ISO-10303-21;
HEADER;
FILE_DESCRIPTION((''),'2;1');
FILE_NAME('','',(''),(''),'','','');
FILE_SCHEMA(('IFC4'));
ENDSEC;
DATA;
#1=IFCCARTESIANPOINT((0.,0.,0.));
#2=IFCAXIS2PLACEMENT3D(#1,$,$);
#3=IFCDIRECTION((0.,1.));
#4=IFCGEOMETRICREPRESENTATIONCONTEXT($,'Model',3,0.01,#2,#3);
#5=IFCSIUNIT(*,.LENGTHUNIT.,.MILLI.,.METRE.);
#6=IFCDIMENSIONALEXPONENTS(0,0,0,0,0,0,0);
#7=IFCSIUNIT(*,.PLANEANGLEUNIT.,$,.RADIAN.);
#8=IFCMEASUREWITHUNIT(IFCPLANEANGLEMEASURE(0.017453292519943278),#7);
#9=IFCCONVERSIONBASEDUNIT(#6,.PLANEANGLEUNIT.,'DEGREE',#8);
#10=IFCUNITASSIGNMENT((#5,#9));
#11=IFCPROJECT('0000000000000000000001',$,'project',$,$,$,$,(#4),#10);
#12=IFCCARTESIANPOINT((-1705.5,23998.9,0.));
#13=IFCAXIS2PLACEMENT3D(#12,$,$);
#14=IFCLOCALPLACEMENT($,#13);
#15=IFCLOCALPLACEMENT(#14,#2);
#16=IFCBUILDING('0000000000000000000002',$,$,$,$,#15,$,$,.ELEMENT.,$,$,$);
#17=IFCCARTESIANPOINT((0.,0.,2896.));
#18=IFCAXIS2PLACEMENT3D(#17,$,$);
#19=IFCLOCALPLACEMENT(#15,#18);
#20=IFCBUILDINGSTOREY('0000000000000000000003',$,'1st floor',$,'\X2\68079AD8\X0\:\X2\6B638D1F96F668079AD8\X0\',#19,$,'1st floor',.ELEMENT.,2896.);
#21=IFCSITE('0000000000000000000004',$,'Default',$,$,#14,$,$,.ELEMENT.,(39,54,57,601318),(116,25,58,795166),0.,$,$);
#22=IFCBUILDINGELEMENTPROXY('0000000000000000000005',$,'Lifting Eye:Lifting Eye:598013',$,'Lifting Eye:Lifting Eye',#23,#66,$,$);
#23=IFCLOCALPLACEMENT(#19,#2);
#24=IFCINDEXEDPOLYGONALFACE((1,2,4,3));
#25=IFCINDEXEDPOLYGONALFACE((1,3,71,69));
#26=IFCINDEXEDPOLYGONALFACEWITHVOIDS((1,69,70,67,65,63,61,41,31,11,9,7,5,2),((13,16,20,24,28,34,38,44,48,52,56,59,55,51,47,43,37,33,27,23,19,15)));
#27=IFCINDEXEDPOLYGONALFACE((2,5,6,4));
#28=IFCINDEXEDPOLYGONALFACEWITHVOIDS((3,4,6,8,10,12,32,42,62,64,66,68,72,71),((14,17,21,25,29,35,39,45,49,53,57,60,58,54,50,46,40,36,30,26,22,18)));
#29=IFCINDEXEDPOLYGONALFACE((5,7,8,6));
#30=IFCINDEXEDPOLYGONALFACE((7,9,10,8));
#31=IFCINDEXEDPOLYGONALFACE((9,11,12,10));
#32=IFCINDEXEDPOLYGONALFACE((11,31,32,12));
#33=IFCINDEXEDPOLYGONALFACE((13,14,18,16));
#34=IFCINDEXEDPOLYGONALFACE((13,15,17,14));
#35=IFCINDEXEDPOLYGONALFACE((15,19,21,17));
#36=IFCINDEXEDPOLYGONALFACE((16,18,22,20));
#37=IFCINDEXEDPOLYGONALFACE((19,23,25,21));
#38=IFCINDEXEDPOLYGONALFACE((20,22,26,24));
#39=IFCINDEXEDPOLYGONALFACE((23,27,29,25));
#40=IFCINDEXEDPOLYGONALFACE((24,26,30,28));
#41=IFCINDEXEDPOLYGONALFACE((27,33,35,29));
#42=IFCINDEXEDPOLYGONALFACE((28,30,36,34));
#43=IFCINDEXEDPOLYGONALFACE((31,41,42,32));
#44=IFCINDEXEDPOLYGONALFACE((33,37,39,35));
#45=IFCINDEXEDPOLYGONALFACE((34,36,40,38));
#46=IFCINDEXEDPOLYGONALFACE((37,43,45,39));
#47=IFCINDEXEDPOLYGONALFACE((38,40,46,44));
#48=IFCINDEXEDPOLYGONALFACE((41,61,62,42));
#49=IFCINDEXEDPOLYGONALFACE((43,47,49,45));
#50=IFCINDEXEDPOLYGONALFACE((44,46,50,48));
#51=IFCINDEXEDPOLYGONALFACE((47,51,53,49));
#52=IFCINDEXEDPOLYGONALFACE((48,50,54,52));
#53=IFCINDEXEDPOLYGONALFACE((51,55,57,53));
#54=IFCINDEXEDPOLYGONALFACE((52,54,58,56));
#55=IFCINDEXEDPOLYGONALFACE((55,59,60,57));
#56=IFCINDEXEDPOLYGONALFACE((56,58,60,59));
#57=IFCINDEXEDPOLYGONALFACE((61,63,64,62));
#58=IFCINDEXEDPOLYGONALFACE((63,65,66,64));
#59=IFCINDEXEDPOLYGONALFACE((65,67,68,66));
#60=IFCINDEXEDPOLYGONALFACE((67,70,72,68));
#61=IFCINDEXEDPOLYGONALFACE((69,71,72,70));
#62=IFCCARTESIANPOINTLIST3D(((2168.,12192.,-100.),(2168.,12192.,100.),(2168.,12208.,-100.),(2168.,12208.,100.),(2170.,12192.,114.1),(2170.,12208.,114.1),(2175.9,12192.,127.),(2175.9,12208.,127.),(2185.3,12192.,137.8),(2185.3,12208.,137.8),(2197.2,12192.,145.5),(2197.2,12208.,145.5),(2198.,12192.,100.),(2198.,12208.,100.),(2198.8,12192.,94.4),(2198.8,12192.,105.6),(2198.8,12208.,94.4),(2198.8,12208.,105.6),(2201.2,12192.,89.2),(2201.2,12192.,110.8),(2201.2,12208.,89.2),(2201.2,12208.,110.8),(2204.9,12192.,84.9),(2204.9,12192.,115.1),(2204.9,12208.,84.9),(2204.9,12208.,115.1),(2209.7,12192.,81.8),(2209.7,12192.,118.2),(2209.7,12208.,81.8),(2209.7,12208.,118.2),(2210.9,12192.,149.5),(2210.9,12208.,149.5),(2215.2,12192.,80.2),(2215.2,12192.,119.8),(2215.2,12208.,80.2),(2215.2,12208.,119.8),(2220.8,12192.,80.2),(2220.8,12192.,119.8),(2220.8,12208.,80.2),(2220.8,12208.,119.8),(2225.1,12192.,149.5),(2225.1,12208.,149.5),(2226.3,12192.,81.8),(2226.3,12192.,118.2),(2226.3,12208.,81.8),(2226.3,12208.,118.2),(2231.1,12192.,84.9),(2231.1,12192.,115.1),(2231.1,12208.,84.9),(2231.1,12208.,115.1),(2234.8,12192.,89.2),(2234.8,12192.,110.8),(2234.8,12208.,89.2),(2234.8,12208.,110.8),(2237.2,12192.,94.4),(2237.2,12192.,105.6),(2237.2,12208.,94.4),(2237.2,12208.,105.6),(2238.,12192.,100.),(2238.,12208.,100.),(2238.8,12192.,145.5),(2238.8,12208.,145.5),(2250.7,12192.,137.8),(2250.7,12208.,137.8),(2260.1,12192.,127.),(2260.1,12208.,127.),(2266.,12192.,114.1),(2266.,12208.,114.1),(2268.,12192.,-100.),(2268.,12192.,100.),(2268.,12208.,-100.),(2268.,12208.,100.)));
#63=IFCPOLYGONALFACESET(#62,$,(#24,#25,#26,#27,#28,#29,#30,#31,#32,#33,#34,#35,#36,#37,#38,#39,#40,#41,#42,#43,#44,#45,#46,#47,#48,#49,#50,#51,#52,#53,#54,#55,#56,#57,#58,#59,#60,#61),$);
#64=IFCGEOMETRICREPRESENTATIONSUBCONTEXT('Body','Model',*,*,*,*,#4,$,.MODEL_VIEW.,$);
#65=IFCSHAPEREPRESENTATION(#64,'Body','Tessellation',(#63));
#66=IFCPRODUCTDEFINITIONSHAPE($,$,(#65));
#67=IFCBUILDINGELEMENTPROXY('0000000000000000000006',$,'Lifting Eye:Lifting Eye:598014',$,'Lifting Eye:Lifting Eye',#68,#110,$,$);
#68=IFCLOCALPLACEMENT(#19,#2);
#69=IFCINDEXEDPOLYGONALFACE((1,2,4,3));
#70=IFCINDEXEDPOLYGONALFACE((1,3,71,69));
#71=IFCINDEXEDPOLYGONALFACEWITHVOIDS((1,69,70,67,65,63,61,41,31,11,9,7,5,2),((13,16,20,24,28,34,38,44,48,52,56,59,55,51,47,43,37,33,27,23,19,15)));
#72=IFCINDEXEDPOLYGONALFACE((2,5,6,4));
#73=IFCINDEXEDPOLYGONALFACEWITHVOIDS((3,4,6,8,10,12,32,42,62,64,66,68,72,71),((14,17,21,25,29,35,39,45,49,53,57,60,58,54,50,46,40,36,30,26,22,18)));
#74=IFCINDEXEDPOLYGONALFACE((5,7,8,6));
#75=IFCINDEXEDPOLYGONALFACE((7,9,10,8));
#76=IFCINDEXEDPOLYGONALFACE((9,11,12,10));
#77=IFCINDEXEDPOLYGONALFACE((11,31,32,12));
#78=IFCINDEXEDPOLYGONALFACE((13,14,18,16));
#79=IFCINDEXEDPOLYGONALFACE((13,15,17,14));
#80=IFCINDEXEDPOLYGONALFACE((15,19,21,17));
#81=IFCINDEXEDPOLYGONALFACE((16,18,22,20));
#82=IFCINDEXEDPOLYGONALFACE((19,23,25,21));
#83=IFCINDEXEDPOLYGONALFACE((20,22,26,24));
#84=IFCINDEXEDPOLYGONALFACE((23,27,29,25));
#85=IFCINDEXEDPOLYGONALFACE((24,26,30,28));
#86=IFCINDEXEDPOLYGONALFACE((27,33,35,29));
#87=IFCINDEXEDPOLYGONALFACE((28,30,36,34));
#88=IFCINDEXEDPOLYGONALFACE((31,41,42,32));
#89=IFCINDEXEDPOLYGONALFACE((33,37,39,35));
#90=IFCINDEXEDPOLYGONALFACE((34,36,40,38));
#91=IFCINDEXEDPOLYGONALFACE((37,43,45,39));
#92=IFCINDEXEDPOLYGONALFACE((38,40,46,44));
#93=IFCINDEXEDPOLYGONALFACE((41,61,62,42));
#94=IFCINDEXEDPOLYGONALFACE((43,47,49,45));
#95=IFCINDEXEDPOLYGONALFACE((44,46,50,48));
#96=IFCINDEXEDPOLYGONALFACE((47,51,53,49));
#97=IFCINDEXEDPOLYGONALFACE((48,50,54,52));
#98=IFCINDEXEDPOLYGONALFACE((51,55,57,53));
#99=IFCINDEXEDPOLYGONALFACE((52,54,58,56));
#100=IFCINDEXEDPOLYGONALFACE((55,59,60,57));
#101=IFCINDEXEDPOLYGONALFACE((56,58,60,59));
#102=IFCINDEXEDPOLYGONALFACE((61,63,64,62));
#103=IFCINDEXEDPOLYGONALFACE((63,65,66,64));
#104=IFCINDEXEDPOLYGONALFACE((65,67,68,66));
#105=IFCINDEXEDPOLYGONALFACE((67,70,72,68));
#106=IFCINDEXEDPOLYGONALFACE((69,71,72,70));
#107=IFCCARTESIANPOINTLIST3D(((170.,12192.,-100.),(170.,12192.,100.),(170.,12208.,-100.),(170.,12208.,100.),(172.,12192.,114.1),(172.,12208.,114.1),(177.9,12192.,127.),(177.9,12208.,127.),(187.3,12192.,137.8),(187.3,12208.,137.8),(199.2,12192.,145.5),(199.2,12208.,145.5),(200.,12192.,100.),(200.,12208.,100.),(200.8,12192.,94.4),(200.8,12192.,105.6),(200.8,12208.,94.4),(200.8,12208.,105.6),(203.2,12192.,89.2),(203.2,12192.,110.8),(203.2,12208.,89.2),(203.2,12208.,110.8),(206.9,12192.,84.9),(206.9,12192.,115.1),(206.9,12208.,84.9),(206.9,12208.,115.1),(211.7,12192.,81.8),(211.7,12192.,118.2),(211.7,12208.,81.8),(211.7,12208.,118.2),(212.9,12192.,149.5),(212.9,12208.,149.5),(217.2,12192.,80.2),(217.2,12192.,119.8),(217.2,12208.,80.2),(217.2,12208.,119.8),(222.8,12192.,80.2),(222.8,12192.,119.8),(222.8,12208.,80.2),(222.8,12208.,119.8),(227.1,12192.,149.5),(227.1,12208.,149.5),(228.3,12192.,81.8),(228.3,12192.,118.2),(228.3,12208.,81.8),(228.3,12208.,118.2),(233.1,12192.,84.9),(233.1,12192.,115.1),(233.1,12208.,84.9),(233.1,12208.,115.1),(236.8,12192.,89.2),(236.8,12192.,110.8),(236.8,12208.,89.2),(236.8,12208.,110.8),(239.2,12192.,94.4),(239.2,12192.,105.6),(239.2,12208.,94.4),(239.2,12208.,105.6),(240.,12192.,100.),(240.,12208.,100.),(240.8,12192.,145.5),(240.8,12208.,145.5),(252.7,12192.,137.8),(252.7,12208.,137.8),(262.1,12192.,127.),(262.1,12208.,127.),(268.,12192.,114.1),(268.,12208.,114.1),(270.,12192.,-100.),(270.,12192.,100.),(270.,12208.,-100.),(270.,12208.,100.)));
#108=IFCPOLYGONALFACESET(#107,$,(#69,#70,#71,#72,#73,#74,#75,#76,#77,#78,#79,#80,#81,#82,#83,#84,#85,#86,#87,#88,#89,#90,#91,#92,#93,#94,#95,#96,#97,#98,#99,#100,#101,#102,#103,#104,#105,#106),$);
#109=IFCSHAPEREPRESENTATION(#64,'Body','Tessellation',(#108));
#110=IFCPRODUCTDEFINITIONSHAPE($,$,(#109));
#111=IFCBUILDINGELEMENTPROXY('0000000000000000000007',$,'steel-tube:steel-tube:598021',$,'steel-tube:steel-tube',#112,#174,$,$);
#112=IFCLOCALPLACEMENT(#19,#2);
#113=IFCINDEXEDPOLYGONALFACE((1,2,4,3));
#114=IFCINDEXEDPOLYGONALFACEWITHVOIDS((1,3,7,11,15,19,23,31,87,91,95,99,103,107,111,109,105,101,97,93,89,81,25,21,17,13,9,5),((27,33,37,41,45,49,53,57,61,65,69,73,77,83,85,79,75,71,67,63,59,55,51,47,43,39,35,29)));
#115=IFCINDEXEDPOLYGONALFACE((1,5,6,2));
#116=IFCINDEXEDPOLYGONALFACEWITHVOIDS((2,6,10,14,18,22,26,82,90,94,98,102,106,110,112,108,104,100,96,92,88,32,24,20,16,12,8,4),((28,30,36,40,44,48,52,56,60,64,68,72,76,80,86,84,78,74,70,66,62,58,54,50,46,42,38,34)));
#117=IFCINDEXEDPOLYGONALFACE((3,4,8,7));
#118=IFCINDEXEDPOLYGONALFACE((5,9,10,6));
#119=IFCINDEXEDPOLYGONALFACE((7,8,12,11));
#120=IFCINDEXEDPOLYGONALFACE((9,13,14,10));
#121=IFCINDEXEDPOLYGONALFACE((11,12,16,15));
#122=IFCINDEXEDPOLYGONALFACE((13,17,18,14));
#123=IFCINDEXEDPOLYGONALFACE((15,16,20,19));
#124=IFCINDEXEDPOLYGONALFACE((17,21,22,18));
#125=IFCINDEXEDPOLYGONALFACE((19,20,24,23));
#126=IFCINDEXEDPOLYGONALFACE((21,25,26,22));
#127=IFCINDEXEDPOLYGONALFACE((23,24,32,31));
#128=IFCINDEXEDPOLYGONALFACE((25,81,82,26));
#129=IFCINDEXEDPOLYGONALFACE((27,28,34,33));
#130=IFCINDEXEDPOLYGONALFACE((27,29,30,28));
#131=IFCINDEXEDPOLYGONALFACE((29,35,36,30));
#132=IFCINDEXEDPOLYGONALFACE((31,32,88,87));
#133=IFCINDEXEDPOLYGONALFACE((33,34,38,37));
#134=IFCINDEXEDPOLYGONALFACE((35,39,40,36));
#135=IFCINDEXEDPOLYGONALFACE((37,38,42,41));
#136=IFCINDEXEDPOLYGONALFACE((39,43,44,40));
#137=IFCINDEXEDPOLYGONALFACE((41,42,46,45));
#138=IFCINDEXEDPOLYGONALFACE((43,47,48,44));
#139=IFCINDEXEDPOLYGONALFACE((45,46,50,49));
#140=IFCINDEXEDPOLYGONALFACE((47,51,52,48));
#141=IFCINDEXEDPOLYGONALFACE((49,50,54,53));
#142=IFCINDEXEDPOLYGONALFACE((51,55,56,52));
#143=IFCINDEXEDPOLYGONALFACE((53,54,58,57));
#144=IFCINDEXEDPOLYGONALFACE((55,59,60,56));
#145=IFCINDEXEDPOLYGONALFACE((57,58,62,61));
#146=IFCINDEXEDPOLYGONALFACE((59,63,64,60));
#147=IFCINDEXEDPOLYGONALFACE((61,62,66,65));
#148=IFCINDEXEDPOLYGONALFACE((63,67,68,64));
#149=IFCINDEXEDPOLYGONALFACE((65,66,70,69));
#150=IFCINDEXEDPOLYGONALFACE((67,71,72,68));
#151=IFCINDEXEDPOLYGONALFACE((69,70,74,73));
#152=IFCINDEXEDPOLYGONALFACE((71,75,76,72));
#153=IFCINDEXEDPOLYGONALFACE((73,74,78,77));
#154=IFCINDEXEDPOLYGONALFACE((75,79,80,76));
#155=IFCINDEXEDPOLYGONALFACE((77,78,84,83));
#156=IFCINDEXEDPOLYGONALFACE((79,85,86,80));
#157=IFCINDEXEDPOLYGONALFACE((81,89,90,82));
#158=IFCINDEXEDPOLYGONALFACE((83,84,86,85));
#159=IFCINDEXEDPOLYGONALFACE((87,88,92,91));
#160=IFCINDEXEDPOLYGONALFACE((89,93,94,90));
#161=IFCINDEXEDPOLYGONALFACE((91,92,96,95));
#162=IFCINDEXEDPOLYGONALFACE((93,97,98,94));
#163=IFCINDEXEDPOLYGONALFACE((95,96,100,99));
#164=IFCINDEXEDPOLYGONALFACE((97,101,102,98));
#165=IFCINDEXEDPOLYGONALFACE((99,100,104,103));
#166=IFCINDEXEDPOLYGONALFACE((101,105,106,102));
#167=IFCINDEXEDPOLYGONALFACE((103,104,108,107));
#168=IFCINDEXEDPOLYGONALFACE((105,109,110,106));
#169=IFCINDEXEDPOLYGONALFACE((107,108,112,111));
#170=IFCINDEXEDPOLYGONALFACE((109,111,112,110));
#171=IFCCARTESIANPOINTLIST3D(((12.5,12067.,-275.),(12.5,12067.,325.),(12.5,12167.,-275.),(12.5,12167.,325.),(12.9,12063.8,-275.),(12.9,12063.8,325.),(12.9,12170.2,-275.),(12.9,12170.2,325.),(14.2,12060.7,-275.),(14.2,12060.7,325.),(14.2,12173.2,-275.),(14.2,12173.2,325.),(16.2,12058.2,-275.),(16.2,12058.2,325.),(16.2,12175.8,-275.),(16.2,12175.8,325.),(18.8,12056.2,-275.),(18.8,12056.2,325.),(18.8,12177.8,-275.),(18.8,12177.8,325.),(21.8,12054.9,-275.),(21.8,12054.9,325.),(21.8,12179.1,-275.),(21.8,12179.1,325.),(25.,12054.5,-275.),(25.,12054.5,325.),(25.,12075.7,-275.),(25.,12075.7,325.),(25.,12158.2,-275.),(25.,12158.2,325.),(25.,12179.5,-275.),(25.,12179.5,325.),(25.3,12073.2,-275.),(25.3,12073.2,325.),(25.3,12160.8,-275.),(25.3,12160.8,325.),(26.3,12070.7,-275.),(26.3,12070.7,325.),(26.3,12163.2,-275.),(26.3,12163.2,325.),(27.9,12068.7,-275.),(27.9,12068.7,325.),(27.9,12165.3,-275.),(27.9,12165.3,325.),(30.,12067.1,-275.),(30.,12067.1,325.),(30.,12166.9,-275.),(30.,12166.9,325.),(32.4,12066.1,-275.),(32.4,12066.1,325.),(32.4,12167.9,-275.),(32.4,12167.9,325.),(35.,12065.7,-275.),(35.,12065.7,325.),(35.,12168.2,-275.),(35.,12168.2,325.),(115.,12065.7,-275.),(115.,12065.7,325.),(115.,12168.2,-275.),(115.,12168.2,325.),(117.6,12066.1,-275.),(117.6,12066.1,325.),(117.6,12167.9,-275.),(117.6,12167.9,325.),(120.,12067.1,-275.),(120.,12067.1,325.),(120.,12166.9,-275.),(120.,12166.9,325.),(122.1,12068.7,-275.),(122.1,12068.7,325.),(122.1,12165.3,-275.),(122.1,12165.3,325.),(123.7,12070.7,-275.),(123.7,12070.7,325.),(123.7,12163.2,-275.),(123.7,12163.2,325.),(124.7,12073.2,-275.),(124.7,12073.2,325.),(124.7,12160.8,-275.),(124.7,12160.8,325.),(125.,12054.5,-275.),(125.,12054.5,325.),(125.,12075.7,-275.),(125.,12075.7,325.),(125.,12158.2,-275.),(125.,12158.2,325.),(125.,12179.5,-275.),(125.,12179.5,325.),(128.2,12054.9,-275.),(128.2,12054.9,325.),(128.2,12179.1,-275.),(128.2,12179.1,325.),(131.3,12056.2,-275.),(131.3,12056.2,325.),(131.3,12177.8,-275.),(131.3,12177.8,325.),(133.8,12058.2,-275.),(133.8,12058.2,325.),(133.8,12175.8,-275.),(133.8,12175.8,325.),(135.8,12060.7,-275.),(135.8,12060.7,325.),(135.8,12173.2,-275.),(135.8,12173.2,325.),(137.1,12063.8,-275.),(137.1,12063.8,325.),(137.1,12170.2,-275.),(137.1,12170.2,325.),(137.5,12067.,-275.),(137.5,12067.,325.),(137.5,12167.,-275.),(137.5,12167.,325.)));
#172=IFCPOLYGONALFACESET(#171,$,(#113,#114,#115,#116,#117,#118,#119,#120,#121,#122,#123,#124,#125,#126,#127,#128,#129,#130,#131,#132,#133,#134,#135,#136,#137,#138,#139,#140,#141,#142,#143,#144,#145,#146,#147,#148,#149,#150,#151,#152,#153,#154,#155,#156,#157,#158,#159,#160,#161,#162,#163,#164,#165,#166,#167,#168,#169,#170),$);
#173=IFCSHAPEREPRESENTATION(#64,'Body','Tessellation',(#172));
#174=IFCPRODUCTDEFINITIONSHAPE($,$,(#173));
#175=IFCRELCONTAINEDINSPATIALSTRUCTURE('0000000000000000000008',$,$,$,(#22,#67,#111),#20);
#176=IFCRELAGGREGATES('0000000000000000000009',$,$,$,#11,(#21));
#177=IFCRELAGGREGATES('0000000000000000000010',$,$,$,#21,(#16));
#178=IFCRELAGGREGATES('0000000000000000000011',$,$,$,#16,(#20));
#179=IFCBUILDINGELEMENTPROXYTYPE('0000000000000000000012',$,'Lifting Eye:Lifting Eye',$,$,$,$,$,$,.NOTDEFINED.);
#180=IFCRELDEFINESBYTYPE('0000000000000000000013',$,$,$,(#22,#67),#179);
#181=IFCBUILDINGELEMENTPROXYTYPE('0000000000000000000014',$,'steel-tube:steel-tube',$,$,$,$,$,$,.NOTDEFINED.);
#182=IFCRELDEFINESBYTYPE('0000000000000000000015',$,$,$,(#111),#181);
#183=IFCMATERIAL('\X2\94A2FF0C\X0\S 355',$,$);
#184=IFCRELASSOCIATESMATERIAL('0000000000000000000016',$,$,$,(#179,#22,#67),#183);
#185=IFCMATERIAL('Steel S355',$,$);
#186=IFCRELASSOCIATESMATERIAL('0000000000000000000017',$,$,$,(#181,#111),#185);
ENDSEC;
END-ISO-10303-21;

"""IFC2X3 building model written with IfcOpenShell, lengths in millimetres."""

from ifc_helpers import new_model, entity, si_unit, converted_unit, direction, frame, frame_2d, origin, place, context, subcontext, project, spatial, polyline, circle_curve, parameter, trimmed, segment, composite_curve, outline, extrude, source, transform, mapped, material, type_object, type_shapes, element, save


model = new_model("IFC2X3")

# Units and contexts
model_context = context("Model", 3, precision=0.01, world=origin(), true_north=direction((0.0, 1.0)))
body_context = subcontext(model_context, "Body", "Model", "MODEL_VIEW")
ifc_project = project(units=[si_unit("LENGTHUNIT", "METRE", prefix="MILLI"), converted_unit("PLANEANGLEUNIT", "DEGREE", entity("IfcPlaneAngleMeasure", 0.017453292519943278), si_unit("PLANEANGLEUNIT", "RADIAN"), dimensions=[0, 0, 0, 0, 0, 0, 0])], contexts=[model_context])

# Site, building, storey
site_placement = place(None, frame((-1705.5, 23998.9, 0.0)))
site = spatial("IfcSite", under=ifc_project, at=site_placement, Name="Default", CompositionType="ELEMENT", RefLatitude=(39, 54, 57, 601318), RefLongitude=(116, 25, 58, 795166), RefElevation=0.0)
building_placement = place(site_placement, origin())
building = spatial("IfcBuilding", under=site, at=building_placement, CompositionType="ELEMENT")
storey_placement = place(building_placement, frame((0.0, 0.0, 2896.0)))
storey = spatial("IfcBuildingStorey", under=building, at=storey_placement, Name="1st floor", ObjectType="标高:正负零标高", LongName="1st floor", CompositionType="ELEMENT", Elevation=2896.0)

# Shared definitions
ifc_material_1 = material(Name="Steel S355")

# Building element proxies
ifc_material_2 = material(Name="钢，S 355")
building_element_proxy_type_1 = type_object("IfcBuildingElementProxyType", Name="Lifting Eye:Lifting Eye", PredefinedType="NOTDEFINED", material=ifc_material_2)
shared_shape_1 = source(origin(), body_context, "Body", "SweptSolid", [
    extrude(outline(composite_curve([segment(polyline([(-100.0, -50.0), (100.0, -50.0)]), True, "CONTINUOUS"), segment(polyline([(100.0, -50.0), (100.0, 50.0)]), True, "CONTINUOUS"), segment(polyline([(100.0, 50.0), (-100.0, 50.0)]), True, "CONTINUOUS"), segment(trimmed(circle_curve(frame_2d((-100.0, 0.0), x_axis=(0.0, -1.0)), 50.0), [parameter(180.0)], [parameter(0.0)], True, "PARAMETER"), True, "CONTINUOUS")], self_intersect=False), holes=[composite_curve([segment(trimmed(circle_curve(frame_2d((-100.0, 0.0), x_axis=(0.0, -1.0)), 20.0), [parameter(180.0)], [parameter(360.0)], True, "PARAMETER"), False, "CONTINUOUS"), segment(trimmed(circle_curve(frame_2d((-100.0, 0.0), x_axis=(0.0, -1.0)), 20.0), [parameter(0.0)], [parameter(180.0)], True, "PARAMETER"), False, "CONTINUOUS")], self_intersect=False)]), frame((0.0, 17.0, -17.0), z_axis=(0.0, 1.0, 0.0), x_axis=(0.0, 0.0, -1.0)), (0.0, 0.0, 1.0), 16.0),
])
type_shapes(building_element_proxy_type_1, [shared_shape_1])
for number, where, name in (
    (1, (2218.0, 12175.0, 17.0), "Lifting Eye:Lifting Eye:598013"),
    (2, (220.0, 12175.0, 17.0), "Lifting Eye:Lifting Eye:598014"),
):
    element("IfcBuildingElementProxy", number, at=place(storey_placement, frame(where)), inside=storey, type_object=building_element_proxy_type_1, material=ifc_material_2, Name=name, ObjectType="Lifting Eye:Lifting Eye", context=body_context, shape_type="MappedRepresentation", body=[
        mapped(shared_shape_1, transform((0.0, 0.0, 0.0), scale=1.0)),
    ])
building_element_proxy_type_2 = type_object("IfcBuildingElementProxyType", Name="steel-tube:steel-tube", PredefinedType="NOTDEFINED", material=ifc_material_1)
shared_shape_2 = source(origin(), body_context, "Body", "SweptSolid", [
    extrude(outline(composite_curve([segment(trimmed(circle_curve(frame_2d((50.0, -50.0), x_axis=(1.0, 0.0)), 12.5), [parameter(270.0)], [parameter(0.0)], True, "PARAMETER"), True, "CONTINUOUS"), segment(polyline([(62.5, -50.0), (62.5, 50.0)]), True, "CONTINUOUS"), segment(trimmed(circle_curve(frame_2d((50.0, 50.0), x_axis=(1.0, 0.0)), 12.5), [parameter(0.0)], [parameter(90.0)], True, "PARAMETER"), True, "CONTINUOUS"), segment(polyline([(50.0, 62.5), (-50.0, 62.5)]), True, "CONTINUOUS"), segment(trimmed(circle_curve(frame_2d((-50.0, 50.0), x_axis=(1.0, 0.0)), 12.5), [parameter(90.0)], [parameter(180.0)], True, "PARAMETER"), True, "CONTINUOUS"), segment(polyline([(-62.5, 50.0), (-62.5, -50.0)]), True, "CONTINUOUS"), segment(trimmed(circle_curve(frame_2d((-50.0, -50.0), x_axis=(1.0, 0.0)), 12.5), [parameter(180.0)], [parameter(270.0)], True, "PARAMETER"), True, "CONTINUOUS"), segment(polyline([(-50.0, -62.5), (50.0, -62.5)]), True, "CONTINUOUS")], self_intersect=False), holes=[composite_curve([segment(trimmed(circle_curve(frame_2d((-41.2, 40.0), x_axis=(1.0, 0.0)), 10.0), [parameter(90.0)], [parameter(180.0)], True, "PARAMETER"), False, "CONTINUOUS"), segment(polyline([(-41.3, 50.0), (41.2, 50.0)]), True, "CONTINUOUS"), segment(trimmed(circle_curve(frame_2d((41.2, 40.0), x_axis=(1.0, 0.0)), 10.0), [parameter(0.0)], [parameter(90.0)], True, "PARAMETER"), False, "CONTINUOUS"), segment(polyline([(51.2, 40.0), (51.2, -40.0)]), True, "CONTINUOUS"), segment(trimmed(circle_curve(frame_2d((41.2, -40.0), x_axis=(1.0, 0.0)), 10.0), [parameter(270.0)], [parameter(360.0)], True, "PARAMETER"), False, "CONTINUOUS"), segment(polyline([(41.2, -50.0), (-41.3, -50.0)]), True, "CONTINUOUS"), segment(trimmed(circle_curve(frame_2d((-41.3, -40.0), x_axis=(1.0, 0.0)), 10.0), [parameter(180.0)], [parameter(270.0)], True, "PARAMETER"), False, "CONTINUOUS"), segment(polyline([(-51.3, -40.0), (-51.3, 40.0)]), True, "CONTINUOUS")], self_intersect=False)]), frame((62.5, 62.5, -175.0)), (0.0, 0.0, 1.0), 600.0),
])
type_shapes(building_element_proxy_type_2, [shared_shape_2])
for number, where, z_axis, x_axis, name in (
    (3, (12.5, 12179.5, -100.0), (0.0, 0.0, 1.0), (0.0, -1.0, 0.0), "steel-tube:steel-tube:598021"),
):
    element("IfcBuildingElementProxy", number, at=place(storey_placement, frame(where, z_axis=z_axis, x_axis=x_axis)), inside=storey, type_object=building_element_proxy_type_2, material=ifc_material_1, Name=name, ObjectType="steel-tube:steel-tube", context=body_context, shape_type="MappedRepresentation", body=[
        mapped(shared_shape_2, transform((0.0, 0.0, 0.0), scale=1.0)),
    ])

save(model, "model.ifc")
